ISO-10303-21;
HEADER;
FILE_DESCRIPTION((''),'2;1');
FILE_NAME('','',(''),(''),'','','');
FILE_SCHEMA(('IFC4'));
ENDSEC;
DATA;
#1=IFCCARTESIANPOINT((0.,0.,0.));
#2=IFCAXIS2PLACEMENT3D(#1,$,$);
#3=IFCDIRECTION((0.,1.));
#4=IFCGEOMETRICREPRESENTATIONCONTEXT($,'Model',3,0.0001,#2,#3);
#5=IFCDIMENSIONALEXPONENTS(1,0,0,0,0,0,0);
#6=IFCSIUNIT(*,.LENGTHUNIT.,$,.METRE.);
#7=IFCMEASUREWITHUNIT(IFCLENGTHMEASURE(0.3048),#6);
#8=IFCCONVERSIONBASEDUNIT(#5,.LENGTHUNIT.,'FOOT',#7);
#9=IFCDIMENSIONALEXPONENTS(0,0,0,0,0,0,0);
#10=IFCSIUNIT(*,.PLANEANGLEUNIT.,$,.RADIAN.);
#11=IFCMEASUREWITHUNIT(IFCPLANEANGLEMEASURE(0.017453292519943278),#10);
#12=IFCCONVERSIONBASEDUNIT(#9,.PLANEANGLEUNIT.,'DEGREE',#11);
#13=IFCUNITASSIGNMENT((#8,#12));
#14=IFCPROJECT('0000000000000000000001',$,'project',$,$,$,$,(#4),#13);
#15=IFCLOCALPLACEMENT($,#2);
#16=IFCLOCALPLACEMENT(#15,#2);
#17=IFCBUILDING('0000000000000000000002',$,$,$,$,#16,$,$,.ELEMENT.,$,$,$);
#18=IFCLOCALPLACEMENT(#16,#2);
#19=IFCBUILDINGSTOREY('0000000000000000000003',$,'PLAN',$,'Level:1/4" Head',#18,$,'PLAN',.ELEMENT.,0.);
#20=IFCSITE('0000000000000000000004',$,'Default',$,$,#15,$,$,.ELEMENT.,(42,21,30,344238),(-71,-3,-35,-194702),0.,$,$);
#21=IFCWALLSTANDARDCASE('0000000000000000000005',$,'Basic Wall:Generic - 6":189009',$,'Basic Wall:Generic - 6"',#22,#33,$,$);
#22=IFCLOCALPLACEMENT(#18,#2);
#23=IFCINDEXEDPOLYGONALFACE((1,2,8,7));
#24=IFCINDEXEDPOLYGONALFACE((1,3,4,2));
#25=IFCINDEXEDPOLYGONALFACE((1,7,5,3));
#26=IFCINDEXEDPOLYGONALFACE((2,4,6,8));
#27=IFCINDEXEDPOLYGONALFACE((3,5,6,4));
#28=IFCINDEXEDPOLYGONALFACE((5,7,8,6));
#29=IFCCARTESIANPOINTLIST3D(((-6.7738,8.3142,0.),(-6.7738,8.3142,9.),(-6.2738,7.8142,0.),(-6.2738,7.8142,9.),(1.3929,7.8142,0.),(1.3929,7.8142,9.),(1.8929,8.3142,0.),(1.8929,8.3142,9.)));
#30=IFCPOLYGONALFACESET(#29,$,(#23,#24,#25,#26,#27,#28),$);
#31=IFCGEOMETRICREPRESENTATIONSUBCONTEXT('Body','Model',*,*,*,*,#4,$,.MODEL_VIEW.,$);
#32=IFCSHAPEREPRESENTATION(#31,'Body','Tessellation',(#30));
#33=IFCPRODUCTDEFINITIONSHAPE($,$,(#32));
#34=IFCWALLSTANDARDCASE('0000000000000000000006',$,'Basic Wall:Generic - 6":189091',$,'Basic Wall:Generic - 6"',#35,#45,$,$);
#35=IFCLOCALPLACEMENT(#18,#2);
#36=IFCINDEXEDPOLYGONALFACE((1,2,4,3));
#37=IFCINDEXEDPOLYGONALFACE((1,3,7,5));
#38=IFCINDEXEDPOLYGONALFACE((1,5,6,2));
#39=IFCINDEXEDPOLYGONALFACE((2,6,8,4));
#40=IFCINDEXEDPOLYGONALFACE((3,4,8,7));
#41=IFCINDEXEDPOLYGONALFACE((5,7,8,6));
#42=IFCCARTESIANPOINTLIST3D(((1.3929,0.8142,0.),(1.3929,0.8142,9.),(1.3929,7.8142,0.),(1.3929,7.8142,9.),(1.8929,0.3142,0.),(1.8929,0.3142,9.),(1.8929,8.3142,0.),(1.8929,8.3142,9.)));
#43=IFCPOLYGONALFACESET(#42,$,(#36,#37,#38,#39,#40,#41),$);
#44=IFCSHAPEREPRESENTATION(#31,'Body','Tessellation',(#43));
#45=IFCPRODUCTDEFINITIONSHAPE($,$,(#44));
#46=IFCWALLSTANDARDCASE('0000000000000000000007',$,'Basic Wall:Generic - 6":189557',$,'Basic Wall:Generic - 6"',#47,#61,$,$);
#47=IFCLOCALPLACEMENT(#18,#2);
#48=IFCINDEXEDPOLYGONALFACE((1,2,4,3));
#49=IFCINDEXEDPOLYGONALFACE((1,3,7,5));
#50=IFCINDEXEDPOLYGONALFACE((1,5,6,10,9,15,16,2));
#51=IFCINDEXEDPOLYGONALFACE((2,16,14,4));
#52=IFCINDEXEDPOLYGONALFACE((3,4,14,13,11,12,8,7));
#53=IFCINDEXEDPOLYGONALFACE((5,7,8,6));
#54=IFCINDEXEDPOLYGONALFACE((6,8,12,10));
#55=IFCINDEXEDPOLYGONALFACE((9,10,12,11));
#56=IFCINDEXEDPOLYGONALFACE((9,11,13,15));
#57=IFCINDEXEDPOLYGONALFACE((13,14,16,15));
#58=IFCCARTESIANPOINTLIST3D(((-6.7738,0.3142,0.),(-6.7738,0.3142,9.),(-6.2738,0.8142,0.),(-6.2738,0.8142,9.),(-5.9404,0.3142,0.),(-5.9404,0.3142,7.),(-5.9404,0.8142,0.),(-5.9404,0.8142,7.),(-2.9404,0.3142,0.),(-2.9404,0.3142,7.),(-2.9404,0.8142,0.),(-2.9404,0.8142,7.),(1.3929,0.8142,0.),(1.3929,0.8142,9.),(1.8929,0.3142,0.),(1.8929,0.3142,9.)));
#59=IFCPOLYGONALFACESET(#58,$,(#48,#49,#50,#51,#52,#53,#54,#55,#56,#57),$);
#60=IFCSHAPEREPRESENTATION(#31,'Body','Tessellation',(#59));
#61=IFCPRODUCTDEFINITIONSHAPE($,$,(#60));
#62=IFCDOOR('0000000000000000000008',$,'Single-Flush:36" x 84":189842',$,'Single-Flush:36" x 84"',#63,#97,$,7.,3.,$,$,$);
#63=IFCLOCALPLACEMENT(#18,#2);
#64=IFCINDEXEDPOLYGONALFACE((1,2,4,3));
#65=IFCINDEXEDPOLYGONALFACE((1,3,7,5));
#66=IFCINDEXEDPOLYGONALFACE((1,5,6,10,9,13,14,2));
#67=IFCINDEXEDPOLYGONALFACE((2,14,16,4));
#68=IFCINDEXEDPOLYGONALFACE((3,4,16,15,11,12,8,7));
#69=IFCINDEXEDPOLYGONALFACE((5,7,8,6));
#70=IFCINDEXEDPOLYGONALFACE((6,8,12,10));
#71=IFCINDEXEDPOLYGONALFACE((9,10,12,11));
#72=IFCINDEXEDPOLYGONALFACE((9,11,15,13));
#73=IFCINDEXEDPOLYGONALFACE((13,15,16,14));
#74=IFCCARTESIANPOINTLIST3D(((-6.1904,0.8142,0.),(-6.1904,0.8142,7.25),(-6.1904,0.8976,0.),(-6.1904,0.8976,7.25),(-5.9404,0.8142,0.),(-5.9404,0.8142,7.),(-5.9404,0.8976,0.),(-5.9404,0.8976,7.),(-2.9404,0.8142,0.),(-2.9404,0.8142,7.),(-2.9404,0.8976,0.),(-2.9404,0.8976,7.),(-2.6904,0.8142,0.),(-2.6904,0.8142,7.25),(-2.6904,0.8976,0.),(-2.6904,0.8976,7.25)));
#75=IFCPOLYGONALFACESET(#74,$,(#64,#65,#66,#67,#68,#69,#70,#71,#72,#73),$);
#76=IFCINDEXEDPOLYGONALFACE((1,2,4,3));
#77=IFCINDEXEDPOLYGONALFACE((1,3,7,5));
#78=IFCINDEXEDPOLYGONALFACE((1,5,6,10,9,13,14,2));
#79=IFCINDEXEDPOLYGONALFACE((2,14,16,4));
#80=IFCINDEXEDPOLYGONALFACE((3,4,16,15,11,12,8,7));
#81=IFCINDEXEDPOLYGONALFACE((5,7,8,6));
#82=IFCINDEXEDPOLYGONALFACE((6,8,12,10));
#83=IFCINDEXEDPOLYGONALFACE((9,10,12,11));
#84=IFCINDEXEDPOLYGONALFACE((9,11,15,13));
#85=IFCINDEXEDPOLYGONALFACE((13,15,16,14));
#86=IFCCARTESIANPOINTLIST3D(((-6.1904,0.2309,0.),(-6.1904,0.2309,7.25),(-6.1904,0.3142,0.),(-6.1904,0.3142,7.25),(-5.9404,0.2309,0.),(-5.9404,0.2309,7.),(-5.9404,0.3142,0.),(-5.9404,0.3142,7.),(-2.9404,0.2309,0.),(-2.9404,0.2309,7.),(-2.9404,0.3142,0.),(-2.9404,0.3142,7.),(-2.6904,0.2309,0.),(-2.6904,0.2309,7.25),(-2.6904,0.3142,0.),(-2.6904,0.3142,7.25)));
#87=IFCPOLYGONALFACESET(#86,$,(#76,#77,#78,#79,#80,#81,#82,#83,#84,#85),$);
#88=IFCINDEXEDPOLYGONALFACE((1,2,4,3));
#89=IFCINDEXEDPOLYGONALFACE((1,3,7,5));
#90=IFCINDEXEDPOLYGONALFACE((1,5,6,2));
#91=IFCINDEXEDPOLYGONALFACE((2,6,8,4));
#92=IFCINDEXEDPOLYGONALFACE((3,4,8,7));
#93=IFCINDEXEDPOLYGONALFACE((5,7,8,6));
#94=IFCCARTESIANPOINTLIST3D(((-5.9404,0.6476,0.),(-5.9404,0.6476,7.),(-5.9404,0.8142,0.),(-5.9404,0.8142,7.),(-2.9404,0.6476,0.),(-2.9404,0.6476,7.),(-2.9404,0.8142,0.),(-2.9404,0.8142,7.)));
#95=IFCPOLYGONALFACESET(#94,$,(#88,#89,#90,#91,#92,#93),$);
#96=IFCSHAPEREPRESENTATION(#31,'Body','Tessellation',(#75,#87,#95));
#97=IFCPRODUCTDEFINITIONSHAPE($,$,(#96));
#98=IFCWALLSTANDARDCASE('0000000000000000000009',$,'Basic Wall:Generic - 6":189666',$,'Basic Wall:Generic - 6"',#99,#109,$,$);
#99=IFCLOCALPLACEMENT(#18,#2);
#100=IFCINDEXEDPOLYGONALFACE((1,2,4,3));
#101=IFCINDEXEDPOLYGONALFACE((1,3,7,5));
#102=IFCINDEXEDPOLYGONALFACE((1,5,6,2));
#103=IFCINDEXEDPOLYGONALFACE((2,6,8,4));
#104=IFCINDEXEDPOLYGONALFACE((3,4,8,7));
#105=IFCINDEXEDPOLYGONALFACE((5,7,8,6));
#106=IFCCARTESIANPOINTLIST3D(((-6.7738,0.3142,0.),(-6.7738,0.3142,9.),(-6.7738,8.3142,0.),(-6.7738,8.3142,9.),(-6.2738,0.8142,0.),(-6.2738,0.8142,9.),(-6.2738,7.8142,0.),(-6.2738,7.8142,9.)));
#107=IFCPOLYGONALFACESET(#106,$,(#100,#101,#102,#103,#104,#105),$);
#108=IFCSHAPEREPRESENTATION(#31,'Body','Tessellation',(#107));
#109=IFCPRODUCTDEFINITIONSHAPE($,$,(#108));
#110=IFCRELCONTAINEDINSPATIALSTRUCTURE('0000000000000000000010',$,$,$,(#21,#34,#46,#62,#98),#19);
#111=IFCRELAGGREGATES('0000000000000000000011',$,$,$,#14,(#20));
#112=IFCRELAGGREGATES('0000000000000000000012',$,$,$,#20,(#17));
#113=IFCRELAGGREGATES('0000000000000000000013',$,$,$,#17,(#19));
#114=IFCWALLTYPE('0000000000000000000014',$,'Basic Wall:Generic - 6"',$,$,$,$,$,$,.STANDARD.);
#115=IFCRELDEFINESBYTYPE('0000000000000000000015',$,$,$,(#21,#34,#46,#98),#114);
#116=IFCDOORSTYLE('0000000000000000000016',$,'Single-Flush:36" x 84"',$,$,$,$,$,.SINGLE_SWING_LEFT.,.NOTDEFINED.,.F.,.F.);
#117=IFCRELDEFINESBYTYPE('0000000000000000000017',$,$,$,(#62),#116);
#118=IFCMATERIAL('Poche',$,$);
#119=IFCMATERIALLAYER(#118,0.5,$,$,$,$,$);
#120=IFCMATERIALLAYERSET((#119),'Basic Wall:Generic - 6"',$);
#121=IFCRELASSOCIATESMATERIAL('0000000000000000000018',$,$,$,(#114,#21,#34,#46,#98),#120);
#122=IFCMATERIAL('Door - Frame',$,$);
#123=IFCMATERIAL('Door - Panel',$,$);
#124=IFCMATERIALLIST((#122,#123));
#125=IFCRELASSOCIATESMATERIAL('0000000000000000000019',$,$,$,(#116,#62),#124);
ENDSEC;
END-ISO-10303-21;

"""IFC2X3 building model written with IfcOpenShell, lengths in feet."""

from ifc_helpers import new_model, entity, si_unit, converted_unit, direction, frame, frame_2d, origin, origin_2d_with_axis, place, context, subcontext, project, spatial, polyline, rectangle, outline, extrude, source, transform, mapped, material, material_list, layer, layer_set, layer_usage, type_object, type_shapes, element, fill, save


model = new_model("IFC2X3")

# Units and contexts
model_context = context("Model", 3, precision=0.0001, world=origin(), true_north=direction((0.0, 1.0)))
body_context = subcontext(model_context, "Body", "Model", "MODEL_VIEW")
ifc_project = project(units=[converted_unit("LENGTHUNIT", "FOOT", entity("IfcLengthMeasure", 0.3048), si_unit("LENGTHUNIT", "METRE"), dimensions=[1, 0, 0, 0, 0, 0, 0]), converted_unit("PLANEANGLEUNIT", "DEGREE", entity("IfcPlaneAngleMeasure", 0.017453292519943278), si_unit("PLANEANGLEUNIT", "RADIAN"), dimensions=[0, 0, 0, 0, 0, 0, 0])], contexts=[model_context])

# Site, building, storey
site_placement = place(None, origin())
site = spatial("IfcSite", under=ifc_project, at=site_placement, Name="Default", CompositionType="ELEMENT", RefLatitude=(42, 21, 30, 344238), RefLongitude=(-71, -3, -35, -194702), RefElevation=0.0)
building_placement = place(site_placement, origin())
building = spatial("IfcBuilding", under=site, at=building_placement, CompositionType="ELEMENT")
storey_placement = place(building_placement, origin())
storey = spatial("IfcBuildingStorey", under=building, at=storey_placement, Name="PLAN", ObjectType="Level:1/4\" Head", LongName="PLAN", CompositionType="ELEMENT", Elevation=0.0)

# Walls
ifc_material_1 = material(Name="Poche")
ifc_layer = layer(ifc_material_1, 0.5)
ifc_layer_set = layer_set([ifc_layer], Name="Basic Wall:Generic - 6\"")
ifc_layer_usage_1 = layer_usage(ifc_layer_set, "AXIS2", "NEGATIVE", 0.25)
wall_type = type_object("IfcWallType", Name="Basic Wall:Generic - 6\"", PredefinedType="STANDARD", material=ifc_layer_set)
wall_1_placement = place(storey_placement, frame((-6.7738, 8.0642, 0.0)))
element("IfcWallStandardCase", 1, at=wall_1_placement, inside=storey, type_object=wall_type, material=ifc_layer_usage_1, Name="Basic Wall:Generic - 6\":189009", ObjectType="Basic Wall:Generic - 6\"", context=body_context, shape_type="SweptSolid", body=[
    extrude(outline(polyline([(8.1667, -0.25), (8.6667, 0.25), (0.0, 0.25), (0.5, -0.25), (8.1667, -0.25)])), origin(), (0.0, 0.0, 1.0), 9.0),
])
ifc_layer_usage_2 = layer_usage(ifc_layer_set, "AXIS2", "NEGATIVE", 0.25)
wall_2_placement = place(storey_placement, frame((1.6429, 8.3142, 0.0), z_axis=(0.0, 0.0, 1.0), x_axis=(0.0, -1.0, 0.0)))
element("IfcWallStandardCase", 2, at=wall_2_placement, inside=storey, type_object=wall_type, material=ifc_layer_usage_2, Name="Basic Wall:Generic - 6\":189091", ObjectType="Basic Wall:Generic - 6\"", context=body_context, shape_type="SweptSolid", body=[
    extrude(outline(polyline([(7.5, -0.25), (8.0, 0.25), (0.0, 0.25), (0.5, -0.25), (7.5, -0.25)])), origin(), (0.0, 0.0, 1.0), 9.0),
])

# Wall, opening, door
ifc_layer_usage_3 = layer_usage(ifc_layer_set, "AXIS2", "NEGATIVE", 0.25)
wall_3_placement = place(storey_placement, frame((1.8929, 0.5642, 0.0), z_axis=(0.0, 0.0, 1.0), x_axis=(-1.0, 0.0, 0.0)))
wall_3 = element("IfcWallStandardCase", 3, at=wall_3_placement, inside=storey, type_object=wall_type, material=ifc_layer_usage_3, Name="Basic Wall:Generic - 6\":189557", ObjectType="Basic Wall:Generic - 6\"", context=body_context, shape_type="SweptSolid", body=[
    extrude(outline(polyline([(0.5, -0.25), (8.1667, -0.25), (8.6667, 0.25), (0.0, 0.25), (0.5, -0.25)])), origin(), (0.0, 0.0, 1.0), 9.0),
])
opening_placement = place(wall_3_placement, frame((7.8333, 0.25, 0.0)))
opening = element("IfcOpeningElement", 4, at=opening_placement, cuts=wall_3, ObjectType="Opening", context=body_context, shape_type="SweptSolid", body=[
    extrude(rectangle(XDim=3.0, YDim=7.0, at=frame_2d((3.5, 1.5), x_axis=(0.0, -1.0))), frame((0.0, 0.0, 0.0), z_axis=(0.0, -1.0, 0.0), x_axis=(0.0, 0.0, 1.0)), (0.0, 0.0, 1.0), 0.5),
])
ifc_material_2 = material(Name="Door - Frame")
ifc_material_3 = material(Name="Door - Panel")
ifc_material_list_1 = material_list([ifc_material_2, ifc_material_3])
door_style = type_object("IfcDoorStyle", Name="Single-Flush:36\" x 84\"", ConstructionType="NOTDEFINED", OperationType="SINGLE_SWING_LEFT", ParameterTakesPrecedence=False, Sizeable=False, material=ifc_material_list_1)
shared_shape_1 = source(origin(), body_context, "Body", "SweptSolid", [
    extrude(outline(polyline([(-1.75, -3.6875), (1.75, -3.6875), (1.75, 3.5625), (1.5, 3.5625), (1.5, -3.4375), (-1.5, -3.4375), (-1.5, 3.5625), (-1.75, 3.5625), (-1.75, -3.6875)])), frame((1.5, 0.5833, 3.5625), z_axis=(0.0, -1.0, 0.0), x_axis=(-1.0, 0.0, 0.0)), (0.0, 0.0, 1.0), 0.0833),
    extrude(outline(polyline([(-3.6875, -1.75), (3.5625, -1.75), (3.5625, -1.5), (-3.4375, -1.5), (-3.4375, 1.5), (3.5625, 1.5), (3.5625, 1.75), (-3.6875, 1.75), (-3.6875, -1.75)])), frame((1.5, 0.0, 3.5625), z_axis=(0.0, -1.0, 0.0), x_axis=(0.0, 0.0, -1.0)), (0.0, 0.0, 1.0), 0.0833),
    extrude(rectangle(XDim=3.0, YDim=0.1667, at=origin_2d_with_axis()), frame((1.5, 0.4167, 0.0)), (0.0, 0.0, 1.0), 7.0),
])
type_shapes(door_style, [shared_shape_1])
door_placement = place(opening_placement, frame((0.0, 0.0, 0.0), z_axis=(0.0, 0.0, 1.0), x_axis=(-1.0, 0.0, 0.0)))
door = element("IfcDoor", 5, at=door_placement, inside=storey, type_object=door_style, material=ifc_material_list_1, Name="Single-Flush:36\" x 84\":189842", ObjectType="Single-Flush:36\" x 84\"", OverallHeight=7.0, OverallWidth=3.0, context=body_context, shape_type="MappedRepresentation", body=[
    mapped(shared_shape_1, transform((0.0, 0.0, 0.0), scale=1.0)),
])
fill(opening, door)

# Wall
ifc_layer_usage_4 = layer_usage(ifc_layer_set, "AXIS2", "NEGATIVE", 0.25)
wall_4_placement = place(storey_placement, frame((-6.5238, 0.3142, 0.0), z_axis=(0.0, 0.0, 1.0), x_axis=(0.0, 1.0, 0.0)))
element("IfcWallStandardCase", 6, at=wall_4_placement, inside=storey, type_object=wall_type, material=ifc_layer_usage_4, Name="Basic Wall:Generic - 6\":189666", ObjectType="Basic Wall:Generic - 6\"", context=body_context, shape_type="SweptSolid", body=[
    extrude(outline(polyline([(7.5, -0.25), (8.0, 0.25), (0.0, 0.25), (0.5, -0.25), (7.5, -0.25)])), origin(), (0.0, 0.0, 1.0), 9.0),
])

save(model, "model.ifc")
